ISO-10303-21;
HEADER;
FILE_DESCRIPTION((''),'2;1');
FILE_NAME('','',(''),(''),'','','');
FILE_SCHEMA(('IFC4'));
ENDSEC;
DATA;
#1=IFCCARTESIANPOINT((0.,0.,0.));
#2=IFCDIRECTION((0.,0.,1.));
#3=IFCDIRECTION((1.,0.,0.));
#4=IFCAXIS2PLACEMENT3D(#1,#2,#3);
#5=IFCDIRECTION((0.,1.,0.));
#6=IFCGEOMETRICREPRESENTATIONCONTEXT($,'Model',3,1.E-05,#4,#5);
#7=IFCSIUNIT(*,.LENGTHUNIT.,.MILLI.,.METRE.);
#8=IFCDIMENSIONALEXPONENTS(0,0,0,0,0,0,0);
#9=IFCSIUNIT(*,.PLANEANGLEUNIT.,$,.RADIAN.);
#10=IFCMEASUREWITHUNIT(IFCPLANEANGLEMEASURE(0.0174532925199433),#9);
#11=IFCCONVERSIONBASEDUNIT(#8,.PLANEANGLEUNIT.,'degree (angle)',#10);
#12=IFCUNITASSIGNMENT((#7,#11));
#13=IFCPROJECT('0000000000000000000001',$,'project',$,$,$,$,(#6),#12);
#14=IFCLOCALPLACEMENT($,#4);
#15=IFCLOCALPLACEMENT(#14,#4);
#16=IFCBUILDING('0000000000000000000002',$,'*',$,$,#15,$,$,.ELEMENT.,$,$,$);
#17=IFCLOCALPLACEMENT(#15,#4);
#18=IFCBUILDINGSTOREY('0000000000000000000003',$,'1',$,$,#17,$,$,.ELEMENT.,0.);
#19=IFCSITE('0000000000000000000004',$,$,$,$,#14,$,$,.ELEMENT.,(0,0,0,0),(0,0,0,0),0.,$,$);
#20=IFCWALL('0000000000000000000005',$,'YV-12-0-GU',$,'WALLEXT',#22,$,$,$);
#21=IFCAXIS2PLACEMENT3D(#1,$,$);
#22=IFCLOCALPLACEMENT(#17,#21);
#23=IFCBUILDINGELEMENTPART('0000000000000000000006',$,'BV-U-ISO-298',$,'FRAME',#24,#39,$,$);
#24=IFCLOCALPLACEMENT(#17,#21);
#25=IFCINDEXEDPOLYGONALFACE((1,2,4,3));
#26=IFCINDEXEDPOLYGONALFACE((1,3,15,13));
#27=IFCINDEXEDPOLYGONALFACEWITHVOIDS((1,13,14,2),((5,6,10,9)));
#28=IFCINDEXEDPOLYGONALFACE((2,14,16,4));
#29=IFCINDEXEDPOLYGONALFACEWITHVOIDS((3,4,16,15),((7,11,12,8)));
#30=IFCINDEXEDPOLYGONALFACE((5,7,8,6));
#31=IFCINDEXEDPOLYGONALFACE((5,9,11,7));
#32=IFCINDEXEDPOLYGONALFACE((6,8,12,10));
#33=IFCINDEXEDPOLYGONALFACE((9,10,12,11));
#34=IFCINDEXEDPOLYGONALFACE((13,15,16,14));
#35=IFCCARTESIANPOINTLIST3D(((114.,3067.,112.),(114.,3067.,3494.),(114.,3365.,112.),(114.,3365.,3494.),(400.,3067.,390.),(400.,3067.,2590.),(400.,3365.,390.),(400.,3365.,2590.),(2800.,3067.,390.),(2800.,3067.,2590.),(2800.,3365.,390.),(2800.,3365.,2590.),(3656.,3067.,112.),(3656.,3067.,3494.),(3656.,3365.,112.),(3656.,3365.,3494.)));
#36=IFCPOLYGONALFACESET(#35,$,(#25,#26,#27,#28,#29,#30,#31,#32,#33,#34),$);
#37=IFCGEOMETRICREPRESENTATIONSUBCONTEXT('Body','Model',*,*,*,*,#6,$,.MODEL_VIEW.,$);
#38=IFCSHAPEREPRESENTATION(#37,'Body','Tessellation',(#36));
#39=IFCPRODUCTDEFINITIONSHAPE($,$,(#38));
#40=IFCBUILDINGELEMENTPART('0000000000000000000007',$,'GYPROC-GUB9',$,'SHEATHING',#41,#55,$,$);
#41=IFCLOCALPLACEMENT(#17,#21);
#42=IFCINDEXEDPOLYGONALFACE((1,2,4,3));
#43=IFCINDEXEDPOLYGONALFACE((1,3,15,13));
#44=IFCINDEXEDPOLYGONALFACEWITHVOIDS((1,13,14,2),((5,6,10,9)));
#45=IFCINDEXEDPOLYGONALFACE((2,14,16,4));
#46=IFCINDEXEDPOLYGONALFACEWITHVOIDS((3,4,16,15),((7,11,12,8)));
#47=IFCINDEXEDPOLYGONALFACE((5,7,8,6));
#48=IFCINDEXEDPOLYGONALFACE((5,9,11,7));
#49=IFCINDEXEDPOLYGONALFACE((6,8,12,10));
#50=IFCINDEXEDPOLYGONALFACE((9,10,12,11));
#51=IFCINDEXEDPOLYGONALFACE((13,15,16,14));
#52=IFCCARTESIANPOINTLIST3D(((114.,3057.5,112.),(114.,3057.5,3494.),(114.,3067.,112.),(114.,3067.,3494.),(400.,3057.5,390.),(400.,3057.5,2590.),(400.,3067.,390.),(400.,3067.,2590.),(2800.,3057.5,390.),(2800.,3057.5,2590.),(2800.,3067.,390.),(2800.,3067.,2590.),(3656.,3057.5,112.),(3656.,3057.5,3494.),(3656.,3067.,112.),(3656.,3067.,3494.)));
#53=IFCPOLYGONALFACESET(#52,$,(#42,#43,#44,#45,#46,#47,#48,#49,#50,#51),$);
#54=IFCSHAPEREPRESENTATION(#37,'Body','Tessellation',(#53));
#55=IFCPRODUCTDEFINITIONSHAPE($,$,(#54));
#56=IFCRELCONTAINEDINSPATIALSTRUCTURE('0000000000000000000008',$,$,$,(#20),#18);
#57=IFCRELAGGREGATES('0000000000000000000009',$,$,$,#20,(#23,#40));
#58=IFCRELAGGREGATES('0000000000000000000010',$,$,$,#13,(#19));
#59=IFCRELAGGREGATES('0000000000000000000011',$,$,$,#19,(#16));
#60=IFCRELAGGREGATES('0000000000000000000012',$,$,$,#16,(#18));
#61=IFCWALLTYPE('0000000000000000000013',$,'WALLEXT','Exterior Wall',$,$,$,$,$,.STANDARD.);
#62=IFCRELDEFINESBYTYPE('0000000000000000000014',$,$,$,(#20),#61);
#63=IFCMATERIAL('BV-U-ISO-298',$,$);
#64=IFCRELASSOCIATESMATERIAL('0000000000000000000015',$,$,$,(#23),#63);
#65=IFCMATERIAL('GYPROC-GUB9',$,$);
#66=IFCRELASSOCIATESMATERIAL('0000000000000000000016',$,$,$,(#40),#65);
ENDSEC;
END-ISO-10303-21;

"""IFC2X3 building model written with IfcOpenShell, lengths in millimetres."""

from ifc_helpers import new_model, entity, si_unit, converted_unit, direction, frame, origin_with_axes, place, context, subcontext, project, spatial, polyline, segment, composite_curve, outline, extrude, material, type_object, element, aggregate, save


model = new_model("IFC2X3")

# Units and contexts
model_context = context("Model", 3, precision=1e-05, world=origin_with_axes(), true_north=direction((0.0, 1.0, 0.0)))
body_context = subcontext(model_context, "Body", "Model", "MODEL_VIEW")
ifc_project = project(units=[si_unit("LENGTHUNIT", "METRE", prefix="MILLI"), converted_unit("PLANEANGLEUNIT", "degree (angle)", entity("IfcPlaneAngleMeasure", 0.0174532925199433), si_unit("PLANEANGLEUNIT", "RADIAN"), dimensions=[0, 0, 0, 0, 0, 0, 0])], contexts=[model_context])

# Site, building, storey
site_placement = place(None, origin_with_axes())
site = spatial("IfcSite", under=ifc_project, at=site_placement, CompositionType="ELEMENT", RefLatitude=(0, 0, 0, 0), RefLongitude=(0, 0, 0, 0), RefElevation=0.0)
building_placement = place(site_placement, origin_with_axes())
building = spatial("IfcBuilding", under=site, at=building_placement, Name="*", CompositionType="ELEMENT")
storey_placement = place(building_placement, origin_with_axes())
storey = spatial("IfcBuildingStorey", under=building, at=storey_placement, Name="1", CompositionType="ELEMENT", Elevation=0.0)

# Shared definitions
ifc_material_1 = material(Name="GYPROC-GUB9")

# Wall, building element parts
wall_type = type_object("IfcWallType", Name="WALLEXT", Description="Exterior Wall", PredefinedType="STANDARD")
wall_placement = place(storey_placement, frame((3656.0, 3216.0, 112.0), z_axis=(0.0, 0.0, 1.0), x_axis=(-1.0, 0.0, 0.0)))
wall = element("IfcWall", 1, at=wall_placement, inside=storey, type_object=wall_type, Name="YV-12-0-GU", ObjectType="WALLEXT")
ifc_material_2 = material(Name="BV-U-ISO-298")
building_element_part_1_placement = place(wall_placement, origin_with_axes())
building_element_part_1 = element("IfcBuildingElementPart", 2, at=building_element_part_1_placement, material=ifc_material_2, Name="BV-U-ISO-298", ObjectType="FRAME", context=body_context, shape_type="SweptSolid", body=[
    extrude(outline(composite_curve([segment(polyline([(-114.0, -3494.0), (-114.0, -112.0), (-3656.0, -112.0), (-3656.0, -3494.0), (-114.0, -3494.0)]), True, "CONTINUOUS")], self_intersect=False), holes=[composite_curve([segment(polyline([(-400.0, -390.0), (-400.0, -2590.0), (-2800.0, -2590.0), (-2800.0, -390.0), (-400.0, -390.0)]), True, "CONTINUOUS")], self_intersect=False)]), frame((3656.0, -149.0, -112.0), z_axis=(0.0, 1.0, 0.0), x_axis=(1.0, 0.0, 0.0)), (0.0, 0.0, 1.0), 298.0),
])
building_element_part_2_placement = place(wall_placement, origin_with_axes())
building_element_part_2 = element("IfcBuildingElementPart", 3, at=building_element_part_2_placement, material=ifc_material_1, Name="GYPROC-GUB9", ObjectType="SHEATHING", context=body_context, shape_type="SweptSolid", body=[
    extrude(outline(composite_curve([segment(polyline([(-114.0, -3494.0), (-114.0, -112.0), (-3656.0, -112.0), (-3656.0, -3494.0), (-114.0, -3494.0)]), True, "CONTINUOUS")], self_intersect=False), holes=[composite_curve([segment(polyline([(-400.0, -390.0), (-400.0, -2590.0), (-2800.0, -2590.0), (-2800.0, -390.0), (-400.0, -390.0)]), True, "CONTINUOUS")], self_intersect=False)]), frame((3656.0, 149.0, -112.0), z_axis=(0.0, 1.0, 0.0), x_axis=(1.0, 0.0, 0.0)), (0.0, 0.0, 1.0), 9.5),
])
aggregate(wall, [building_element_part_1, building_element_part_2])

save(model, "model.ifc")
